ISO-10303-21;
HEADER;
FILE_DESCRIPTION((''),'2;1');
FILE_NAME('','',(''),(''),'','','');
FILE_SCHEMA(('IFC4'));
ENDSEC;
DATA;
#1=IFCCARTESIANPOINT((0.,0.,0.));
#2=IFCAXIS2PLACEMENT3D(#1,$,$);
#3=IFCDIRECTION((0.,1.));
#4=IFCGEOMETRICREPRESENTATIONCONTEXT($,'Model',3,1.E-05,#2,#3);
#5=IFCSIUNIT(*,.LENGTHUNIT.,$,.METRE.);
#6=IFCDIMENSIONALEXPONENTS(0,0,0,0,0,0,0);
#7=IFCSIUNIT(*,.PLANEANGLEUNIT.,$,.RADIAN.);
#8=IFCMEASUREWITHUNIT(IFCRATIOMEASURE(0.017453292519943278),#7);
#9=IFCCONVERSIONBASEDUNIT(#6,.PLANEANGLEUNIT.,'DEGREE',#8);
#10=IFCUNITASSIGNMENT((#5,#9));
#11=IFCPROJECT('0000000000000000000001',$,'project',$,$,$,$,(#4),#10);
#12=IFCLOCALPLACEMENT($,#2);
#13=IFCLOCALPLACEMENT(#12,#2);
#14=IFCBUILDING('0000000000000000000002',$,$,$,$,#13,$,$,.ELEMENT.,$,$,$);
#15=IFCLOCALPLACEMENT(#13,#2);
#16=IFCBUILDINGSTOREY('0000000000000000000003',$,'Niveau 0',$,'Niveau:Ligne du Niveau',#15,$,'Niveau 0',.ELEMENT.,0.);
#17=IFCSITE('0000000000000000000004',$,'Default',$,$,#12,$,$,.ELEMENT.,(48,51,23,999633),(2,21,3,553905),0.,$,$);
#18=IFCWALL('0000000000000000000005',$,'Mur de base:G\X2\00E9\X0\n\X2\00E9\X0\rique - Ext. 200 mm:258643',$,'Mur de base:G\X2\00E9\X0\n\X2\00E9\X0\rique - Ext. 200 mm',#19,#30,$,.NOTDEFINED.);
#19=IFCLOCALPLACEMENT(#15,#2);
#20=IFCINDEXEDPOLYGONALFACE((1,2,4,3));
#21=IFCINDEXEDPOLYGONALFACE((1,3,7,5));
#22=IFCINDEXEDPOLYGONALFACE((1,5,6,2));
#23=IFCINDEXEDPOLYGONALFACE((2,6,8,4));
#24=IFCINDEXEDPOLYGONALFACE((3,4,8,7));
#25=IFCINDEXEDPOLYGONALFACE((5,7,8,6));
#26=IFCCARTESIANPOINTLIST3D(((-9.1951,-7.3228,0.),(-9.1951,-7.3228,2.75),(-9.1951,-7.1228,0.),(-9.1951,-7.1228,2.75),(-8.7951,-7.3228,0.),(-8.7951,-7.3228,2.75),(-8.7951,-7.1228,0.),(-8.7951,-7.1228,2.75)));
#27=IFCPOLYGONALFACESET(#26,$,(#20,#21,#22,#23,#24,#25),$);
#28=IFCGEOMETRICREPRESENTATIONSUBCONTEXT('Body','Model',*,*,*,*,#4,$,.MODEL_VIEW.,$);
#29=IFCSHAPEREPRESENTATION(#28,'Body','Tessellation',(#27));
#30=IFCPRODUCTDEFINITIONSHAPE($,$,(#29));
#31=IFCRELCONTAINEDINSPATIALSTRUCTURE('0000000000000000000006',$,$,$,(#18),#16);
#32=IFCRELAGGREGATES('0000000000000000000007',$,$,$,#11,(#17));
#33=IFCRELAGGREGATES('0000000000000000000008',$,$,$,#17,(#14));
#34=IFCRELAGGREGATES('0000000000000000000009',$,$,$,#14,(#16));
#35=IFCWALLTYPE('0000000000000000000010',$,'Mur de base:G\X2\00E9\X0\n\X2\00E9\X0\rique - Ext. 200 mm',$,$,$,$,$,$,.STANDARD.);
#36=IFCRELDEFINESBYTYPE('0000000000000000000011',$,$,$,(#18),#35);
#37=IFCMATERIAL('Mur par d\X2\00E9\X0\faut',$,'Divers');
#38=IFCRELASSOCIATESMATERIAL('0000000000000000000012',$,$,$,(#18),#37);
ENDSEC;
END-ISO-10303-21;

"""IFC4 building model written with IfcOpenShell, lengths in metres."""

from ifc_helpers import new_model, entity, si_unit, converted_unit, direction, frame, origin, place, context, subcontext, project, spatial, indexed_curve, outline, extrude, material, type_object, element, save


model = new_model("IFC4")

# Units and contexts
model_context = context("Model", 3, precision=1e-05, world=origin(), true_north=direction((0.0, 1.0)))
body_context = subcontext(model_context, "Body", "Model", "MODEL_VIEW")
ifc_project = project(units=[si_unit("LENGTHUNIT", "METRE"), converted_unit("PLANEANGLEUNIT", "DEGREE", entity("IfcRatioMeasure", 0.017453292519943278), si_unit("PLANEANGLEUNIT", "RADIAN"), dimensions=[0, 0, 0, 0, 0, 0, 0])], contexts=[model_context])

# Site, building, storey
site_placement = place(None, origin())
site = spatial("IfcSite", under=ifc_project, at=site_placement, Name="Default", CompositionType="ELEMENT", RefLatitude=(48, 51, 23, 999633), RefLongitude=(2, 21, 3, 553905), RefElevation=0.0)
building_placement = place(site_placement, origin())
building = spatial("IfcBuilding", under=site, at=building_placement, CompositionType="ELEMENT")
storey_placement = place(building_placement, origin())
storey = spatial("IfcBuildingStorey", under=building, at=storey_placement, Name="Niveau 0", ObjectType="Niveau:Ligne du Niveau", LongName="Niveau 0", CompositionType="ELEMENT", Elevation=0.0)

# Wall
ifc_material = material(Name="Mur par défaut", Category="Divers")
wall_type = type_object("IfcWallType", Name="Mur de base:Générique - Ext. 200 mm", PredefinedType="STANDARD")
wall_placement = place(storey_placement, frame((-9.1951, -7.2228, 0.0)))
element("IfcWall", 1, at=wall_placement, inside=storey, type_object=wall_type, material=ifc_material, Name="Mur de base:Générique - Ext. 200 mm:258643", ObjectType="Mur de base:Générique - Ext. 200 mm", PredefinedType="NOTDEFINED", context=body_context, shape_type="SweptSolid", body=[
    extrude(outline(indexed_curve([(0.4, 0.1), (0.0, 0.1), (0.0, -0.1), (0.4, -0.1), (0.4, 0.1)], self_intersect=False)), origin(), (0.0, 0.0, 1.0), 2.75),
])

save(model, "model.ifc")
